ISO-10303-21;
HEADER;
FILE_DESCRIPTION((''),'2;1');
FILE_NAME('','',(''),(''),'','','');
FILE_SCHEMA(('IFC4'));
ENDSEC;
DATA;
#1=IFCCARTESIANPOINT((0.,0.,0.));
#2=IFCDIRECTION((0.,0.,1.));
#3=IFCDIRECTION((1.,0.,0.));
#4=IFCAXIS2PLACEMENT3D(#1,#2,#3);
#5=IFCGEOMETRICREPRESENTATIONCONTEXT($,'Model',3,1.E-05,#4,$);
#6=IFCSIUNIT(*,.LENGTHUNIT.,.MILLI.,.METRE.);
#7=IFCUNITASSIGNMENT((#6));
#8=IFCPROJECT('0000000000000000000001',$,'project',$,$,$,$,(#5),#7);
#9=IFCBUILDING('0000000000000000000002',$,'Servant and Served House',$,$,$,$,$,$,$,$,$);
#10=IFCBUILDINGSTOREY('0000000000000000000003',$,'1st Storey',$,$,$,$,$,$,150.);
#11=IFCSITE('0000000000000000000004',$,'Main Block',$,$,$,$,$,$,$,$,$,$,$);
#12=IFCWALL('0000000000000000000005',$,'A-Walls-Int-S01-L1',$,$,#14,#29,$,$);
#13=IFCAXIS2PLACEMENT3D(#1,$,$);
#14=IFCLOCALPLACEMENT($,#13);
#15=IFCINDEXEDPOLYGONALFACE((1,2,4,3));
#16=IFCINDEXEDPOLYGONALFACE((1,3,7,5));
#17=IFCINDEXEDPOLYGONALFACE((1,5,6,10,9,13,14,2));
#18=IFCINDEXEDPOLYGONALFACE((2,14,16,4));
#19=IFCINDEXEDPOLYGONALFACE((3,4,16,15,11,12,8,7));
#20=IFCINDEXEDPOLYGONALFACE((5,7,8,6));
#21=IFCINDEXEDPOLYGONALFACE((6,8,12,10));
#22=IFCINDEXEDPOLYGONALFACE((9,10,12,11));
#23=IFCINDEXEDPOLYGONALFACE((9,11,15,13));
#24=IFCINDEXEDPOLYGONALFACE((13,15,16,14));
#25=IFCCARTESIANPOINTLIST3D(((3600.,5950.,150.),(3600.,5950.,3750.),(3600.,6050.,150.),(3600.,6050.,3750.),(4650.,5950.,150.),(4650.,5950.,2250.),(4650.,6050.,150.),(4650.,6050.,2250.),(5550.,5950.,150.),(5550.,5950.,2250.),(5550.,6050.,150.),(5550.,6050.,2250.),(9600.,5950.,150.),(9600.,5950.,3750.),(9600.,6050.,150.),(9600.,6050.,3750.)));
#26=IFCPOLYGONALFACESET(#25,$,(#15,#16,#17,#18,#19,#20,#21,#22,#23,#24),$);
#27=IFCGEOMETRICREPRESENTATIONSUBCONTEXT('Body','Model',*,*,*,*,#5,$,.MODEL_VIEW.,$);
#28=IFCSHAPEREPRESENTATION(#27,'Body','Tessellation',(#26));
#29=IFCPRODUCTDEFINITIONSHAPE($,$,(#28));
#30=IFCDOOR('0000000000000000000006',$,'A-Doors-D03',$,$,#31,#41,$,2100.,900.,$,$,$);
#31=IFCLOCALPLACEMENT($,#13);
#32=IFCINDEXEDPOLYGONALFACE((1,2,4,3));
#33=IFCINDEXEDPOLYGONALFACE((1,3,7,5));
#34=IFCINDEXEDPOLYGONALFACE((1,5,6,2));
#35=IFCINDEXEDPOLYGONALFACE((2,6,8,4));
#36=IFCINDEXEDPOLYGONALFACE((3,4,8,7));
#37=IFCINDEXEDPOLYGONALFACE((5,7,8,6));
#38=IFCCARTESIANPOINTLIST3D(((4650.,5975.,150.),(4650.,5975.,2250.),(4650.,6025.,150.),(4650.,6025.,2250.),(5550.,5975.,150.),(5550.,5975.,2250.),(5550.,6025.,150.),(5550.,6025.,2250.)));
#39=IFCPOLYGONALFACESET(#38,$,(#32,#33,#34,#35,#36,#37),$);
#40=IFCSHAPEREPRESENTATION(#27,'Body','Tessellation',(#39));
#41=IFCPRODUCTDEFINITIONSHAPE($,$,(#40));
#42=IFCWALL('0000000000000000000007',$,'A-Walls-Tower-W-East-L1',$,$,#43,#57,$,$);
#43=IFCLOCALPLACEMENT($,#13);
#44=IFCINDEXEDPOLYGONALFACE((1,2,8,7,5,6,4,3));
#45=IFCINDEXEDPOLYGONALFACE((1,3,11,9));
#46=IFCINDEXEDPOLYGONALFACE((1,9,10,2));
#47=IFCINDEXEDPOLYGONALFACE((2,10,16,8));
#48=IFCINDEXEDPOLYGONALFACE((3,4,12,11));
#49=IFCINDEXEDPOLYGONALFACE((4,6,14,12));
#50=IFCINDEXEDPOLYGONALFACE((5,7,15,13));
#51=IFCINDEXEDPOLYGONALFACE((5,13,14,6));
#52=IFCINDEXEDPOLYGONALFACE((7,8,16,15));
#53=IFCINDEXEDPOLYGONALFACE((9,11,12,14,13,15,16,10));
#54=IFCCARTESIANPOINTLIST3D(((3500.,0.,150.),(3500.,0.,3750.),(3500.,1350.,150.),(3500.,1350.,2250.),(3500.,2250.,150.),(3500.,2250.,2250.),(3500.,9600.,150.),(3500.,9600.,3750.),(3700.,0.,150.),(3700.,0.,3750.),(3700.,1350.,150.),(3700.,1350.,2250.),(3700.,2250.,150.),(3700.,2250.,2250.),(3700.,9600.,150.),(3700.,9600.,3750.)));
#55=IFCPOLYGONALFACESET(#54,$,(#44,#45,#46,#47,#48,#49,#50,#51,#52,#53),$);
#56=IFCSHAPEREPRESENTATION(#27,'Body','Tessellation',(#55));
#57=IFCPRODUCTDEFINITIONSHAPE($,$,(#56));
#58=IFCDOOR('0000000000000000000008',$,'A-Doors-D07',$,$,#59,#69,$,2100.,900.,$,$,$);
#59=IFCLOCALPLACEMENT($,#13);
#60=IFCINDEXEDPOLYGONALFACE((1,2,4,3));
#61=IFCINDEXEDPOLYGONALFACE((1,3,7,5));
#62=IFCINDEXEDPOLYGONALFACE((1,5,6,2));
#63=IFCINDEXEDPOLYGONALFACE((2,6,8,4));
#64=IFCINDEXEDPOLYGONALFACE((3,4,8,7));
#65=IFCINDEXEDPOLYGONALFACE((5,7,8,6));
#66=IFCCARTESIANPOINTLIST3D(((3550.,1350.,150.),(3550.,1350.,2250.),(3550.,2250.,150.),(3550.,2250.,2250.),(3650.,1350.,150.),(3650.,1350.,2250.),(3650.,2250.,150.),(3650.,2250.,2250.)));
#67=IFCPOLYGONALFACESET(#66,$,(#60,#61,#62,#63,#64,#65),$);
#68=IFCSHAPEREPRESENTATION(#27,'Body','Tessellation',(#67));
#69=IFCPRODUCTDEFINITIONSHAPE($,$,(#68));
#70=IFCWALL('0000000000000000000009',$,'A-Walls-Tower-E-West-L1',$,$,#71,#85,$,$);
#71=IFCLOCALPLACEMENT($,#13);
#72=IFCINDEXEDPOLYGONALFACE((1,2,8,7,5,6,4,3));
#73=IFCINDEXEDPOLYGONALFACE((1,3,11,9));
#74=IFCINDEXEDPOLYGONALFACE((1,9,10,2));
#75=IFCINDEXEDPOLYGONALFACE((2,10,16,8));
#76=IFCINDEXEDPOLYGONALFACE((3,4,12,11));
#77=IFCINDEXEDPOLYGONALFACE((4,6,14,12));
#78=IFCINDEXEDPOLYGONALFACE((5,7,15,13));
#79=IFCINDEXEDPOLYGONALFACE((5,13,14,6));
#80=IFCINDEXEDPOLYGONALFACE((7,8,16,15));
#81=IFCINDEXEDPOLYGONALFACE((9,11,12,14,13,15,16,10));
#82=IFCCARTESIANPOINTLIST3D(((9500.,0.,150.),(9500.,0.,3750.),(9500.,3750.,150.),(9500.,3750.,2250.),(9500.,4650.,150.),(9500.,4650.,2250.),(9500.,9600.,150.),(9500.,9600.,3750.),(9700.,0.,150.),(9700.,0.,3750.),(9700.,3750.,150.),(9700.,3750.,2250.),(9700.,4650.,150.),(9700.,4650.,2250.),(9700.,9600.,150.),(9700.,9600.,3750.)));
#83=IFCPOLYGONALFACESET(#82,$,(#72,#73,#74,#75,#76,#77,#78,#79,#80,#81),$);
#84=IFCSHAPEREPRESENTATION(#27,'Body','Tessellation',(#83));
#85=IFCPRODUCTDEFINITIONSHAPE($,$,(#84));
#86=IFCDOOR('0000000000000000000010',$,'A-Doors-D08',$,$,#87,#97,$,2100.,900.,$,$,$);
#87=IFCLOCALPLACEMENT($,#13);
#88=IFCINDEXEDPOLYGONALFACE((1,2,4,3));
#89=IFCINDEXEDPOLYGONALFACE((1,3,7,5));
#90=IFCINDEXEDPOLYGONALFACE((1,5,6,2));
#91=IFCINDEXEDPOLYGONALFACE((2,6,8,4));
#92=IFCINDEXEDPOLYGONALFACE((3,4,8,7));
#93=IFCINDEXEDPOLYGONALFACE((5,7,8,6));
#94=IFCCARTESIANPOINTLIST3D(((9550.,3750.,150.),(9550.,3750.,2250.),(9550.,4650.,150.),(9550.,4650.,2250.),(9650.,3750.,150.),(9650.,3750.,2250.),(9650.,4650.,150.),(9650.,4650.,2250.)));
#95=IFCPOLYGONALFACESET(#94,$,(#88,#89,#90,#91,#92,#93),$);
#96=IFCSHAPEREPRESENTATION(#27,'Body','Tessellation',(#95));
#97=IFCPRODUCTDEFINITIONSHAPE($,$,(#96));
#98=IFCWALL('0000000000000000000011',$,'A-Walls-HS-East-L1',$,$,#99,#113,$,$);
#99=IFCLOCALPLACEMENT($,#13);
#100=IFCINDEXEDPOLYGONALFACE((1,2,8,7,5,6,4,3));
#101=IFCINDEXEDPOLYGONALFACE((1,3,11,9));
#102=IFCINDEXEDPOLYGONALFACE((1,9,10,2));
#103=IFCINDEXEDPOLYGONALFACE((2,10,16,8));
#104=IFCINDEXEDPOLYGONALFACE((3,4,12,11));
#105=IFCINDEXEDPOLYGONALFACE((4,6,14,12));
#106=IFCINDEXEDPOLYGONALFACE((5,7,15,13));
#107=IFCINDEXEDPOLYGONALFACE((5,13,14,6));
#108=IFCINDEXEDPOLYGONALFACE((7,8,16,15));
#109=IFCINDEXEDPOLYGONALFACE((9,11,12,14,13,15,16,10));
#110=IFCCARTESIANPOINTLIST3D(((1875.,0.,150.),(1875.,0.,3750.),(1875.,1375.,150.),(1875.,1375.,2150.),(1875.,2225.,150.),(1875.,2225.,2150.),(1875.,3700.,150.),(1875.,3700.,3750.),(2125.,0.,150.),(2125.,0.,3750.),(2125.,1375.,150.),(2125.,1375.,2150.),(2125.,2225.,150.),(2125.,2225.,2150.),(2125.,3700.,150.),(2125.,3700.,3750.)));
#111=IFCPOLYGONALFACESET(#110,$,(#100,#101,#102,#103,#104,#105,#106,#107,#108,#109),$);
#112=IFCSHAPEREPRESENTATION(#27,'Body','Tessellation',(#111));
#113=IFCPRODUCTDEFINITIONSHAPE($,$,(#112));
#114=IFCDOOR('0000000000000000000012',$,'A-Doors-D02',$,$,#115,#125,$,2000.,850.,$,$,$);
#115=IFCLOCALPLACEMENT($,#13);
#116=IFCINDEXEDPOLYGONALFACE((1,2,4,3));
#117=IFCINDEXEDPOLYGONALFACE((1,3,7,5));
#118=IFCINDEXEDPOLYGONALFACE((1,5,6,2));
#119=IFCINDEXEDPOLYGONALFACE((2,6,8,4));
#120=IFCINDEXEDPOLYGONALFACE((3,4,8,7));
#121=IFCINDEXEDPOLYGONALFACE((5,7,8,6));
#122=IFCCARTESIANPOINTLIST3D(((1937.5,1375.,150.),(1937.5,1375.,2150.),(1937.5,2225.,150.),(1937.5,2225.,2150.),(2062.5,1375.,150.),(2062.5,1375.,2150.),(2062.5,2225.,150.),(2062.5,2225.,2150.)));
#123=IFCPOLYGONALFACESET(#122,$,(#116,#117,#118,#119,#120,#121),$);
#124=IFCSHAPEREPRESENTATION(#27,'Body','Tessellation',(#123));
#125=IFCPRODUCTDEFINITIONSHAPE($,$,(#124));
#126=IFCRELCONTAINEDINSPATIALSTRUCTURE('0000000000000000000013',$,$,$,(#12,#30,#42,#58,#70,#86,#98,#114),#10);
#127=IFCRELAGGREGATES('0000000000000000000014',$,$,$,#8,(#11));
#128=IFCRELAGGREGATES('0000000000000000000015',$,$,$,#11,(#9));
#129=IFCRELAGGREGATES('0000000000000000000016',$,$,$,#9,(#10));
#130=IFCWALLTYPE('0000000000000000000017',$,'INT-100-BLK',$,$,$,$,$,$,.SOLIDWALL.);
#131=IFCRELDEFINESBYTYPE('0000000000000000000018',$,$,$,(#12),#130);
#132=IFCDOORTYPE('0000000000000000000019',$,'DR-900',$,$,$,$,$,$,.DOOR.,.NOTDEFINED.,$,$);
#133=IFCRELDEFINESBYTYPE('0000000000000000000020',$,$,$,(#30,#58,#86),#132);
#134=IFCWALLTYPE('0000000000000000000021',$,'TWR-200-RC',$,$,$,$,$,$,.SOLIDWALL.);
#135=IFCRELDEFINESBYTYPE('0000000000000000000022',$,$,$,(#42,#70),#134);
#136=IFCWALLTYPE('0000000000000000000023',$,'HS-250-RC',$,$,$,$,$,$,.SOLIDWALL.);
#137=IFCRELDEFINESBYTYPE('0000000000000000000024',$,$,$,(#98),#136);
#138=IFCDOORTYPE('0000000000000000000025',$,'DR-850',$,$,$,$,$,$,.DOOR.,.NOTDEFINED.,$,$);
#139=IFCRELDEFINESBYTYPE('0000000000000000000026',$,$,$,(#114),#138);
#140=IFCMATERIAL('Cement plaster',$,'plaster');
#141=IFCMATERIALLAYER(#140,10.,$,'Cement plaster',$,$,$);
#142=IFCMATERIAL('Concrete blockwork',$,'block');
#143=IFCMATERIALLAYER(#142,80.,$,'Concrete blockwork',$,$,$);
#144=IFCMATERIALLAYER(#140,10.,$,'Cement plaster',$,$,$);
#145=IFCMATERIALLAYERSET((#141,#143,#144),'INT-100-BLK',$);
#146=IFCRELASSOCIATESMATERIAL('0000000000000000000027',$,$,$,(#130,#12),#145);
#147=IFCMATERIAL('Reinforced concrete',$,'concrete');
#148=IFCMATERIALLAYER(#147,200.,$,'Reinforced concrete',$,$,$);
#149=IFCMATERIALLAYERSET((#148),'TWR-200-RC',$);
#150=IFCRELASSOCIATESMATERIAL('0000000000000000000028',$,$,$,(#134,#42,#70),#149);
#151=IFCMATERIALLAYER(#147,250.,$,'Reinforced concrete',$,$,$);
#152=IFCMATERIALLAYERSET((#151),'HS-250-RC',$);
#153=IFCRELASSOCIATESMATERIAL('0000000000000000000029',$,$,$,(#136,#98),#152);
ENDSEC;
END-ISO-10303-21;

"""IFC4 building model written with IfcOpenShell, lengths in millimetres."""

from ifc_helpers import new_model, si_unit, frame, origin_with_axes, place, context, subcontext, project, spatial, indexed_curve, outline, extrude, material, layer, layer_set, layer_usage, type_object, element, fill, save


model = new_model("IFC4")

# Units and contexts
model_context = context("Model", 3, precision=1e-05, world=origin_with_axes())
body_context = subcontext(model_context, "Body", "Model", "MODEL_VIEW")
ifc_project = project(units=[si_unit("LENGTHUNIT", "METRE", prefix="MILLI")], contexts=[model_context])

# Site, building, storey
site = spatial("IfcSite", under=ifc_project, Name="Main Block")
building = spatial("IfcBuilding", under=site, Name="Servant and Served House")
storey = spatial("IfcBuildingStorey", under=building, Name="1st Storey", Elevation=150.0)

# Shared definitions
ifc_material_1 = material(Name="Cement plaster", Category="plaster")

# Walls, openings, doors
ifc_layer_1 = layer(ifc_material_1, 10.0, Name="Cement plaster")
ifc_material_2 = material(Name="Concrete blockwork", Category="block")
ifc_layer_2 = layer(ifc_material_2, 80.0, Name="Concrete blockwork")
ifc_layer_3 = layer(ifc_material_1, 10.0, Name="Cement plaster")
ifc_layer_set_1 = layer_set([ifc_layer_1, ifc_layer_2, ifc_layer_3], Name="INT-100-BLK")
wall_type_1 = type_object("IfcWallType", Name="INT-100-BLK", PredefinedType="SOLIDWALL", material=ifc_layer_set_1)
door_type_1 = type_object("IfcDoorType", Name="DR-900", OperationType="NOTDEFINED", PredefinedType="DOOR")
ifc_layer_usage_1 = layer_usage(ifc_layer_set_1, "AXIS2", "POSITIVE", 0.0)
wall_1_placement = place(None, frame((3600.0, 5950.0, 150.0), z_axis=(0.0, 0.0, 1.0), x_axis=(1.0, 0.0, 0.0)))
wall_1 = element("IfcWall", 1, at=wall_1_placement, inside=storey, type_object=wall_type_1, material=ifc_layer_usage_1, Name="A-Walls-Int-S01-L1", context=body_context, shape_type="SweptSolid", body=[
    extrude(outline(indexed_curve([(0.0, 0.0), (0.0, 100.0), (6000.0, 100.0), (6000.0, 0.0), (0.0, 0.0)], self_intersect=False)), origin_with_axes(), (0.0, 0.0, 1.0), 3600.0),
])
opening_1_placement = place(wall_1_placement, frame((1500.0, 50.0, 0.0), z_axis=(0.0, 0.0, 1.0), x_axis=(1.0, 0.0, 0.0)))
opening_1 = element("IfcOpeningElement", 2, at=opening_1_placement, cuts=wall_1, PredefinedType="OPENING", context=body_context, shape_type="SweptSolid", body=[
    extrude(outline(indexed_curve([(-450.0, -100.0), (450.0, -100.0), (450.0, 100.0), (-450.0, 100.0)])), None, (0.0, 0.0, 1.0), 2100.0),
])
door_1_placement = place(None, frame((5100.0, 6000.0, 150.0), z_axis=(0.0, 0.0, 1.0), x_axis=(1.0, 0.0, 0.0)))
door_1 = element("IfcDoor", 3, at=door_1_placement, inside=storey, type_object=door_type_1, Name="A-Doors-D03", OverallHeight=2100.0, OverallWidth=900.0, context=body_context, shape_type="SweptSolid", body=[
    extrude(outline(indexed_curve([(-450.0, -25.0), (450.0, -25.0), (450.0, 25.0), (-450.0, 25.0)])), None, (0.0, 0.0, 1.0), 2100.0),
])
fill(opening_1, door_1)
ifc_material_3 = material(Name="Reinforced concrete", Category="concrete")
ifc_layer_4 = layer(ifc_material_3, 200.0, Name="Reinforced concrete")
ifc_layer_set_2 = layer_set([ifc_layer_4], Name="TWR-200-RC")
ifc_layer_usage_2 = layer_usage(ifc_layer_set_2, "AXIS2", "POSITIVE", 0.0)
wall_type_2 = type_object("IfcWallType", Name="TWR-200-RC", PredefinedType="SOLIDWALL", material=ifc_layer_set_2)
wall_2_placement = place(None, frame((3700.0, 0.0, 150.0), z_axis=(0.0, 0.0, 1.0), x_axis=(0.0, 1.0, 0.0)))
wall_2 = element("IfcWall", 4, at=wall_2_placement, inside=storey, type_object=wall_type_2, material=ifc_layer_usage_2, Name="A-Walls-Tower-W-East-L1", context=body_context, shape_type="SweptSolid", body=[
    extrude(outline(indexed_curve([(0.0, 0.0), (0.0, 200.0), (9600.0, 200.0), (9600.0, 0.0), (0.0, 0.0)], self_intersect=False)), origin_with_axes(), (0.0, 0.0, 1.0), 3600.0),
])
opening_2_placement = place(wall_2_placement, frame((1800.0, 100.0, 0.0), z_axis=(0.0, 0.0, 1.0), x_axis=(1.0, 0.0, 0.0)))
opening_2 = element("IfcOpeningElement", 5, at=opening_2_placement, cuts=wall_2, PredefinedType="OPENING", context=body_context, shape_type="SweptSolid", body=[
    extrude(outline(indexed_curve([(-450.0, -150.0), (450.0, -150.0), (450.0, 150.0), (-450.0, 150.0)])), None, (0.0, 0.0, 1.0), 2100.0),
])
door_2_placement = place(None, frame((3600.0, 1800.0, 150.0), z_axis=(0.0, 0.0, 1.0), x_axis=(0.0, 1.0, 0.0)))
door_2 = element("IfcDoor", 6, at=door_2_placement, inside=storey, type_object=door_type_1, Name="A-Doors-D07", OverallHeight=2100.0, OverallWidth=900.0, context=body_context, shape_type="SweptSolid", body=[
    extrude(outline(indexed_curve([(-450.0, -50.0), (450.0, -50.0), (450.0, 50.0), (-450.0, 50.0)])), None, (0.0, 0.0, 1.0), 2100.0),
])
fill(opening_2, door_2)
ifc_layer_usage_3 = layer_usage(ifc_layer_set_2, "AXIS2", "POSITIVE", 0.0)
wall_3_placement = place(None, frame((9700.0, 0.0, 150.0), z_axis=(0.0, 0.0, 1.0), x_axis=(0.0, 1.0, 0.0)))
wall_3 = element("IfcWall", 7, at=wall_3_placement, inside=storey, type_object=wall_type_2, material=ifc_layer_usage_3, Name="A-Walls-Tower-E-West-L1", context=body_context, shape_type="SweptSolid", body=[
    extrude(outline(indexed_curve([(0.0, 0.0), (0.0, 200.0), (9600.0, 200.0), (9600.0, 0.0), (0.0, 0.0)], self_intersect=False)), origin_with_axes(), (0.0, 0.0, 1.0), 3600.0),
])
opening_3_placement = place(wall_3_placement, frame((4200.0, 100.0, 0.0), z_axis=(0.0, 0.0, 1.0), x_axis=(1.0, 0.0, 0.0)))
opening_3 = element("IfcOpeningElement", 8, at=opening_3_placement, cuts=wall_3, PredefinedType="OPENING", context=body_context, shape_type="SweptSolid", body=[
    extrude(outline(indexed_curve([(-450.0, -150.0), (450.0, -150.0), (450.0, 150.0), (-450.0, 150.0)])), None, (0.0, 0.0, 1.0), 2100.0),
])
door_3_placement = place(None, frame((9600.0, 4200.0, 150.0), z_axis=(0.0, 0.0, 1.0), x_axis=(0.0, 1.0, 0.0)))
door_3 = element("IfcDoor", 9, at=door_3_placement, inside=storey, type_object=door_type_1, Name="A-Doors-D08", OverallHeight=2100.0, OverallWidth=900.0, context=body_context, shape_type="SweptSolid", body=[
    extrude(outline(indexed_curve([(-450.0, -50.0), (450.0, -50.0), (450.0, 50.0), (-450.0, 50.0)])), None, (0.0, 0.0, 1.0), 2100.0),
])
fill(opening_3, door_3)
ifc_layer_5 = layer(ifc_material_3, 250.0, Name="Reinforced concrete")
ifc_layer_set_3 = layer_set([ifc_layer_5], Name="HS-250-RC")
ifc_layer_usage_4 = layer_usage(ifc_layer_set_3, "AXIS2", "POSITIVE", 0.0)
wall_type_3 = type_object("IfcWallType", Name="HS-250-RC", PredefinedType="SOLIDWALL", material=ifc_layer_set_3)
wall_4_placement = place(None, frame((2125.0, 0.0, 150.0), z_axis=(0.0, 0.0, 1.0), x_axis=(0.0, 1.0, 0.0)))
wall_4 = element("IfcWall", 10, at=wall_4_placement, inside=storey, type_object=wall_type_3, material=ifc_layer_usage_4, Name="A-Walls-HS-East-L1", context=body_context, shape_type="SweptSolid", body=[
    extrude(outline(indexed_curve([(0.0, 0.0), (0.0, 250.0), (3700.0, 250.0), (3700.0, 0.0), (0.0, 0.0)], self_intersect=False)), origin_with_axes(), (0.0, 0.0, 1.0), 3600.0),
])
opening_4_placement = place(wall_4_placement, frame((1800.0, 125.0, 0.0), z_axis=(0.0, 0.0, 1.0), x_axis=(1.0, 0.0, 0.0)))
opening_4 = element("IfcOpeningElement", 11, at=opening_4_placement, cuts=wall_4, PredefinedType="OPENING", context=body_context, shape_type="SweptSolid", body=[
    extrude(outline(indexed_curve([(-425.0, -175.0), (425.0, -175.0), (425.0, 175.0), (-425.0, 175.0)])), None, (0.0, 0.0, 1.0), 2000.0),
])
door_type_2 = type_object("IfcDoorType", Name="DR-850", OperationType="NOTDEFINED", PredefinedType="DOOR")
door_4_placement = place(None, frame((2000.0, 1800.0, 150.0), z_axis=(0.0, 0.0, 1.0), x_axis=(0.0, 1.0, 0.0)))
door_4 = element("IfcDoor", 12, at=door_4_placement, inside=storey, type_object=door_type_2, Name="A-Doors-D02", OverallHeight=2000.0, OverallWidth=850.0, context=body_context, shape_type="SweptSolid", body=[
    extrude(outline(indexed_curve([(-425.0, -62.5), (425.0, -62.5), (425.0, 62.5), (-425.0, 62.5)])), None, (0.0, 0.0, 1.0), 2000.0),
])
fill(opening_4, door_4)

save(model, "model.ifc")
